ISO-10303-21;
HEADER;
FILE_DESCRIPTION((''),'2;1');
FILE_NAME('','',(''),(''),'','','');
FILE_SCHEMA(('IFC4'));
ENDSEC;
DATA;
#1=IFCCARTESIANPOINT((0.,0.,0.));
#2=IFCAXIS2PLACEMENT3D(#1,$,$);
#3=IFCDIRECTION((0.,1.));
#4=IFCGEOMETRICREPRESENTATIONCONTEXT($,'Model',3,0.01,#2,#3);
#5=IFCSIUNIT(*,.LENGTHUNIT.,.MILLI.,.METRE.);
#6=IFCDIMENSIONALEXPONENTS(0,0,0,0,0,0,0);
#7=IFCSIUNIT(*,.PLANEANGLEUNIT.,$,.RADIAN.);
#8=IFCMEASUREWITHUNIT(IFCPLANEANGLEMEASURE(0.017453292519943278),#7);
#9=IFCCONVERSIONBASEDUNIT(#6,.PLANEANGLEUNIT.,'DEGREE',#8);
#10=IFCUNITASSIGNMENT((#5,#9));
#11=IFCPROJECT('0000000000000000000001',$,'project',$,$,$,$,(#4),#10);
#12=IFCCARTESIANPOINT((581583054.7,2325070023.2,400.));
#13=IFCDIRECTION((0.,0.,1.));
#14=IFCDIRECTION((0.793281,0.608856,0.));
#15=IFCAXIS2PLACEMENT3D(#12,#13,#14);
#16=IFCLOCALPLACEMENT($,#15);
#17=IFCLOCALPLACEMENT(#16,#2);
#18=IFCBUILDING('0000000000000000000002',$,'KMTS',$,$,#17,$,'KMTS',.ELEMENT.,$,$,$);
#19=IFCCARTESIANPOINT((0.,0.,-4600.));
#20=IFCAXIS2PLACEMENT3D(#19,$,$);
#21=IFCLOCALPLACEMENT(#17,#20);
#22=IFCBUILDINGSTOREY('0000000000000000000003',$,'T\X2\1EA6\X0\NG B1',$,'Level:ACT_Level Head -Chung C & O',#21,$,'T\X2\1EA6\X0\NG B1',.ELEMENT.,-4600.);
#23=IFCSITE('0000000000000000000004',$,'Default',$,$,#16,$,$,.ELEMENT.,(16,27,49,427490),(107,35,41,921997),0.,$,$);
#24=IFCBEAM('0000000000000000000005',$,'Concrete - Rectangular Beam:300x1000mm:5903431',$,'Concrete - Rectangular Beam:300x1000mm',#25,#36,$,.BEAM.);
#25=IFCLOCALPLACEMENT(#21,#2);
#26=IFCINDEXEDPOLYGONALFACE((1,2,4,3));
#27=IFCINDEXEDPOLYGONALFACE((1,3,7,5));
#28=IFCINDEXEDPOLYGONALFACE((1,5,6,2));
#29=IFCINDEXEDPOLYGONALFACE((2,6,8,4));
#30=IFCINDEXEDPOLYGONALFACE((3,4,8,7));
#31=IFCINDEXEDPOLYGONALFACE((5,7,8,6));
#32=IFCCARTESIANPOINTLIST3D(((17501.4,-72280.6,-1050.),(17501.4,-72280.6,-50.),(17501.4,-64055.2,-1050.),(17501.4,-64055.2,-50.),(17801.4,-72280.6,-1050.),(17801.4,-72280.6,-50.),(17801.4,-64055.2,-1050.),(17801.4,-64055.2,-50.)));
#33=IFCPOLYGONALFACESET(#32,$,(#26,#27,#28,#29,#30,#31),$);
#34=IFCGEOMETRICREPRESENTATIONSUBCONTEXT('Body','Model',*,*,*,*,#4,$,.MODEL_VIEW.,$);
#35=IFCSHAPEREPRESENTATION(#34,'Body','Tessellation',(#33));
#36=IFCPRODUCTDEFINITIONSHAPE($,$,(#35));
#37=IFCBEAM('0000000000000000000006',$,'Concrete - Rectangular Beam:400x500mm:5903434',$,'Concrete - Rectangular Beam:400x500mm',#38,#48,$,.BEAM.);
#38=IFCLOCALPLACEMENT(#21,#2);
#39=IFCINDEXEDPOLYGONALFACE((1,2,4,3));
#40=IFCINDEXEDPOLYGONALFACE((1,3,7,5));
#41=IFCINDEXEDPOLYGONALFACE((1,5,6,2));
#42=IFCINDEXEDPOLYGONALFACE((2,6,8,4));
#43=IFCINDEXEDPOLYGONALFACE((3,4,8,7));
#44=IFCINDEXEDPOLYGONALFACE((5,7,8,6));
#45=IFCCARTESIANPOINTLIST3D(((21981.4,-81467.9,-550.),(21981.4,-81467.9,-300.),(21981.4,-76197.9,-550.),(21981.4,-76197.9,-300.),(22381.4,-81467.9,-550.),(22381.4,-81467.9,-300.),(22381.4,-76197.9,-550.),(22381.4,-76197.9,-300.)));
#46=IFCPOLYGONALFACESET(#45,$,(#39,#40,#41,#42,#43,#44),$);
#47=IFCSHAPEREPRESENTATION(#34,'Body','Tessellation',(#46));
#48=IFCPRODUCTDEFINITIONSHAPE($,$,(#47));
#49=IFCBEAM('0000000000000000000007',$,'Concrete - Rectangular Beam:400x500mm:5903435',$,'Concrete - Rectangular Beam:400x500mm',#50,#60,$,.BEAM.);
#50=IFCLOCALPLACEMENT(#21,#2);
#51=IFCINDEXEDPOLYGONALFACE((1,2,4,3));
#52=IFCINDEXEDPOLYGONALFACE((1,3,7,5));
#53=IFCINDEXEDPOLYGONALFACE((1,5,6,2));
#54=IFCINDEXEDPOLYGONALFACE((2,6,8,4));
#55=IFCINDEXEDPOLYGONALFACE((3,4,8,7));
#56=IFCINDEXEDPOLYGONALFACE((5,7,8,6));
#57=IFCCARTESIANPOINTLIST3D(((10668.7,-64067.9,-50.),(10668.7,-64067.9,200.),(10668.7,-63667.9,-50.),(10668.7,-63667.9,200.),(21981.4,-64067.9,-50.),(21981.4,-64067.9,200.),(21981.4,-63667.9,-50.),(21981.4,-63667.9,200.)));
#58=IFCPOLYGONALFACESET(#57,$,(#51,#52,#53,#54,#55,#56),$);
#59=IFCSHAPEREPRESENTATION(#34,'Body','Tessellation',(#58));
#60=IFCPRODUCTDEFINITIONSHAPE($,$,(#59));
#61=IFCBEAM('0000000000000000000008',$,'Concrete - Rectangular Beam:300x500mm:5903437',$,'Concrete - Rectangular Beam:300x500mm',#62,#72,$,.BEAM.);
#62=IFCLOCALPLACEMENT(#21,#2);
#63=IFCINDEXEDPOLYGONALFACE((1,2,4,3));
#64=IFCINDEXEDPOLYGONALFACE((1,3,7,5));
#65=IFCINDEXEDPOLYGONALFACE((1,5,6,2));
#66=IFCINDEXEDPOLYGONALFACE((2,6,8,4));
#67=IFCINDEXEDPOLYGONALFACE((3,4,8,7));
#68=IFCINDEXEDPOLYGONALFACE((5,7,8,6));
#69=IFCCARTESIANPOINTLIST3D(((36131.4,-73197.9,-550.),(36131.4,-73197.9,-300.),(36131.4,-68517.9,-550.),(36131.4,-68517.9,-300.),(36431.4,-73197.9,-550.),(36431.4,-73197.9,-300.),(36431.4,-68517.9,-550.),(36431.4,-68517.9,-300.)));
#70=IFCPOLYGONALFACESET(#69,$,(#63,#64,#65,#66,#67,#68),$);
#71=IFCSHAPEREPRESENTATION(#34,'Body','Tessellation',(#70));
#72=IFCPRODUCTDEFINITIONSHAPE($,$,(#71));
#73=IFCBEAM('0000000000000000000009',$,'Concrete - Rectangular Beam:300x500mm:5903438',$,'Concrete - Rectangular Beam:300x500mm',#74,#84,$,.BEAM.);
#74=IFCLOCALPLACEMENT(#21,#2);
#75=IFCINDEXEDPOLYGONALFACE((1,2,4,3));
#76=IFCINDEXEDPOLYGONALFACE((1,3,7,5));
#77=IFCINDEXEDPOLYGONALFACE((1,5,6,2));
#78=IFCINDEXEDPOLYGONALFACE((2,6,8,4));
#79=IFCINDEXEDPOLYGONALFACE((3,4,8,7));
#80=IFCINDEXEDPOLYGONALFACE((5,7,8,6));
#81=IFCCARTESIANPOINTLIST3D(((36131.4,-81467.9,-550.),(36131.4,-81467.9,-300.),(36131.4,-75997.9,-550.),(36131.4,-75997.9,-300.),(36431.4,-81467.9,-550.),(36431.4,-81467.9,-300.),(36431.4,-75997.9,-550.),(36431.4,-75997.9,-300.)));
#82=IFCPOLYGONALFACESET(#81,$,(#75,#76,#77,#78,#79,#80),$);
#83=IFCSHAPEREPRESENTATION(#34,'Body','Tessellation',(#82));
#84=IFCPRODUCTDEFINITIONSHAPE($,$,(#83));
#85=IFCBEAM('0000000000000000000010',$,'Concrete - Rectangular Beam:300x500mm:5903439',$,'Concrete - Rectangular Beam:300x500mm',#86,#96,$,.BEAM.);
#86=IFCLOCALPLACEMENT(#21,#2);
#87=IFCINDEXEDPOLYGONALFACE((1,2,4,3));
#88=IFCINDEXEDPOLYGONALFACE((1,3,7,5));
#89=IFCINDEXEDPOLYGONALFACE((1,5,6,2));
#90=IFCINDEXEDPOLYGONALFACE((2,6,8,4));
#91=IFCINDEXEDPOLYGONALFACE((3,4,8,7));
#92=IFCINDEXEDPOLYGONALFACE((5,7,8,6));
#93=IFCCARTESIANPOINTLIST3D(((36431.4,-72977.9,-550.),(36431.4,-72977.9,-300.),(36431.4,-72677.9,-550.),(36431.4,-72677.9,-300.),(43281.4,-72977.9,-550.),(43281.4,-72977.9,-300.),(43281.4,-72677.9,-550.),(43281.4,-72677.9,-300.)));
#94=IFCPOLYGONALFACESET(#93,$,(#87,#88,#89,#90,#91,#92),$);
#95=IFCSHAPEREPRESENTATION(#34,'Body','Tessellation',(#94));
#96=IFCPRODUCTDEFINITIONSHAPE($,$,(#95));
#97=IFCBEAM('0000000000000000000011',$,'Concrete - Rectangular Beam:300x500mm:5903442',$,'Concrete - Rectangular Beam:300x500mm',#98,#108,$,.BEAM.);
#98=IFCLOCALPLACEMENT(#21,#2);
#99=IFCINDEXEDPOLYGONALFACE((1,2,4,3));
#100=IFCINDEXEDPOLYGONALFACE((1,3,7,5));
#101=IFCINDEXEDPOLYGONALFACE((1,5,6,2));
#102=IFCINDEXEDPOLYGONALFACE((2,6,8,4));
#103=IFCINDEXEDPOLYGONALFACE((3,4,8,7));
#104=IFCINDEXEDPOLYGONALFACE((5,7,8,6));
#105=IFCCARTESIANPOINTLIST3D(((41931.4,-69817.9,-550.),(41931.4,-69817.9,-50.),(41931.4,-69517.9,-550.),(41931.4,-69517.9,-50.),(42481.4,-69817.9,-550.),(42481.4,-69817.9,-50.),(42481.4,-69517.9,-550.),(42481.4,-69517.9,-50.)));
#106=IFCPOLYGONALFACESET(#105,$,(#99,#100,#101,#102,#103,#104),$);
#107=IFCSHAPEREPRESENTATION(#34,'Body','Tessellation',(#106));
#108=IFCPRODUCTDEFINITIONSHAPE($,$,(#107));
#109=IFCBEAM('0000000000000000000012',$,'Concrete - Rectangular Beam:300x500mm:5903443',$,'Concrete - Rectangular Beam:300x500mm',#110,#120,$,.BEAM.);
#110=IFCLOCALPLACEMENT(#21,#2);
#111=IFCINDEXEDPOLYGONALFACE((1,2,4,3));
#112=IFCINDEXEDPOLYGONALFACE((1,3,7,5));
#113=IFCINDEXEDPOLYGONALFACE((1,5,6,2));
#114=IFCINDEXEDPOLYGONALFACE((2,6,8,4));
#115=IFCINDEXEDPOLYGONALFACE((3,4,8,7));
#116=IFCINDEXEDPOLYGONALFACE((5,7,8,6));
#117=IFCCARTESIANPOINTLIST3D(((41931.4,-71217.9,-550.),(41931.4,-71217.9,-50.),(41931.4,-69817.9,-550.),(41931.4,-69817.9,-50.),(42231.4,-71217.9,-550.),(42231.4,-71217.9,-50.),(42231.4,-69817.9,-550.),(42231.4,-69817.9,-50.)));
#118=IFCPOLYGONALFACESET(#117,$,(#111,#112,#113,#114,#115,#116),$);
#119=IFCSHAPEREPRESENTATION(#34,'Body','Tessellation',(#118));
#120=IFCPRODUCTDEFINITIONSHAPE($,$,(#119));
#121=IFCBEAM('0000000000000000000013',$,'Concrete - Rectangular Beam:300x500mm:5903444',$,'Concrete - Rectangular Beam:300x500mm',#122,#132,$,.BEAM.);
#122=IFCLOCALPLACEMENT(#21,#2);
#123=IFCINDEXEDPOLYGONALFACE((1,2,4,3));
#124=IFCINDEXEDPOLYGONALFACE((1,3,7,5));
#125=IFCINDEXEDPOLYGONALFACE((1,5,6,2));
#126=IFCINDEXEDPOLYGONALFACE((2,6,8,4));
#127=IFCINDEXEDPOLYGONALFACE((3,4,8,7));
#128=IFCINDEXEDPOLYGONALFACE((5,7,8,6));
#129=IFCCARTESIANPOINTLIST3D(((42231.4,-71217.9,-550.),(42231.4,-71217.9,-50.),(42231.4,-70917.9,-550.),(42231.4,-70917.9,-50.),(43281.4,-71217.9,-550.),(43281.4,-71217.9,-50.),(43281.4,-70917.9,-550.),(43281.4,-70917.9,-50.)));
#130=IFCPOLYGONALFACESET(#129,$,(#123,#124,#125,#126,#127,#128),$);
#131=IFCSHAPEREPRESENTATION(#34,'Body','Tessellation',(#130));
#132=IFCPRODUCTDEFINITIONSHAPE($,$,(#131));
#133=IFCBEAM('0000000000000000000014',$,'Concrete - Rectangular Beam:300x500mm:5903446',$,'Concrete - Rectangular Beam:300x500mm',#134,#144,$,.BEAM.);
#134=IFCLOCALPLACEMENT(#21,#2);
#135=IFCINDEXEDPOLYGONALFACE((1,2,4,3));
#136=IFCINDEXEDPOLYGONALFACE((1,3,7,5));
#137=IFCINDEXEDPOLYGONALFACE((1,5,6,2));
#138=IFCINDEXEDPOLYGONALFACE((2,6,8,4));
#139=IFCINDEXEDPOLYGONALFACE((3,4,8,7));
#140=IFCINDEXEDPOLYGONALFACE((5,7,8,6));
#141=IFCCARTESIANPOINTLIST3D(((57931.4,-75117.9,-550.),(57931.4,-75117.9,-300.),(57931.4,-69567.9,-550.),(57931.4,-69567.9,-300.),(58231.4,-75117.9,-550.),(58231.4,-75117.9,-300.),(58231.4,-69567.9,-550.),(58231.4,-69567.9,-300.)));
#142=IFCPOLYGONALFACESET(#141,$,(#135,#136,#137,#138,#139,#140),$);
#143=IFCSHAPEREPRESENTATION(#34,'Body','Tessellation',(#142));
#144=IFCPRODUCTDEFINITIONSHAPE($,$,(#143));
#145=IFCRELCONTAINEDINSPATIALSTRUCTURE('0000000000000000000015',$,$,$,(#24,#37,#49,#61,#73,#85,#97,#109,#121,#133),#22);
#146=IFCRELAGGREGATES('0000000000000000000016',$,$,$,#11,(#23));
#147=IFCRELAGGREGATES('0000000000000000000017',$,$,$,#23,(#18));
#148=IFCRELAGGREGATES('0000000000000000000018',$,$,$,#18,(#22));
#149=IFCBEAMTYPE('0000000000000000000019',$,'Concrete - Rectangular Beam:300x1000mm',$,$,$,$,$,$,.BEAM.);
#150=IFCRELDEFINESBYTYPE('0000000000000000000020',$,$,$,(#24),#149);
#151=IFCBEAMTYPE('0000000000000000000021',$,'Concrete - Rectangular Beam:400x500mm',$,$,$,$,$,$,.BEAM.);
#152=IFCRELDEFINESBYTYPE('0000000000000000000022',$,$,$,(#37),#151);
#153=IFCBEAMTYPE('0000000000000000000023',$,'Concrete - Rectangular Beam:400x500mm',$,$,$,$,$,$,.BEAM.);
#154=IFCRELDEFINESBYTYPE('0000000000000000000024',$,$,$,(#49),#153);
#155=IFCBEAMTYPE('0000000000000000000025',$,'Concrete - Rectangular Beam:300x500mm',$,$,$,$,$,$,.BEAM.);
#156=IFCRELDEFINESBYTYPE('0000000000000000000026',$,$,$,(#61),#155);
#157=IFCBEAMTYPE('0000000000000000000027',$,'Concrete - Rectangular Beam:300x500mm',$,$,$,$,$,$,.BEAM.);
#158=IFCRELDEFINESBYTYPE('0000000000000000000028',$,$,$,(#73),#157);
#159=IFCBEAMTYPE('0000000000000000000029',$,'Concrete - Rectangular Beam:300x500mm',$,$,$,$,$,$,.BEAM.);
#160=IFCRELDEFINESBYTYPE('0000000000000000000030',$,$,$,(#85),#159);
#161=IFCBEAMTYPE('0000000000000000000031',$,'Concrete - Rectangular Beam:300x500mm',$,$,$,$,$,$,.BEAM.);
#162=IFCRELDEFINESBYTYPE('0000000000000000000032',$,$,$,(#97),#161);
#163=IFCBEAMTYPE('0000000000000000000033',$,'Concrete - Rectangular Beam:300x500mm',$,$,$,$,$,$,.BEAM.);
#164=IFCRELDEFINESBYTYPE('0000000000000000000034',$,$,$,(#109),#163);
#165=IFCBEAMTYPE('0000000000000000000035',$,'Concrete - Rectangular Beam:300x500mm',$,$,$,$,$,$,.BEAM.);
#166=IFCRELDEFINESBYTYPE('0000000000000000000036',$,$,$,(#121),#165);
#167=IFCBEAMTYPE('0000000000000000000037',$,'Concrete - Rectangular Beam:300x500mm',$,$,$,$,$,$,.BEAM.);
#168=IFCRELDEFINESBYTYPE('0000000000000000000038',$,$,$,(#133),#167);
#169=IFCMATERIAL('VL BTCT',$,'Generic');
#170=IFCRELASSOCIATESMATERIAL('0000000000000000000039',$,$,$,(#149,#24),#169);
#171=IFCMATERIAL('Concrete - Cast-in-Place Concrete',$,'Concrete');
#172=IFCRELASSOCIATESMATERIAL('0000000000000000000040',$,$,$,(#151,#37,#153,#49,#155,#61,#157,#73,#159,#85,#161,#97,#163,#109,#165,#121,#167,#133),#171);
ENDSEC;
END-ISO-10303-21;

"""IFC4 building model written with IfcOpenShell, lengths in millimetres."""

from ifc_helpers import new_model, entity, si_unit, converted_unit, direction, frame, origin, place, context, subcontext, project, spatial, indexed_curve, outline, extrude, source, transform, mapped, material, type_object, type_shapes, element, save


model = new_model("IFC4")

# Units and contexts
model_context = context("Model", 3, precision=0.01, world=origin(), true_north=direction((0.0, 1.0)))
body_context = subcontext(model_context, "Body", "Model", "MODEL_VIEW")
ifc_project = project(units=[si_unit("LENGTHUNIT", "METRE", prefix="MILLI"), converted_unit("PLANEANGLEUNIT", "DEGREE", entity("IfcPlaneAngleMeasure", 0.017453292519943278), si_unit("PLANEANGLEUNIT", "RADIAN"), dimensions=[0, 0, 0, 0, 0, 0, 0])], contexts=[model_context])

# Site, building, storey
site_placement = place(None, frame((581583054.7, 2325070023.2, 400.0), z_axis=(0.0, 0.0, 1.0), x_axis=(0.793281, 0.608856, 0.0)))
site = spatial("IfcSite", under=ifc_project, at=site_placement, Name="Default", CompositionType="ELEMENT", RefLatitude=(16, 27, 49, 427490), RefLongitude=(107, 35, 41, 921997), RefElevation=0.0)
building_placement = place(site_placement, origin())
building = spatial("IfcBuilding", under=site, at=building_placement, Name="KMTS", LongName="KMTS", CompositionType="ELEMENT")
storey_placement = place(building_placement, frame((0.0, 0.0, -4600.0)))
storey = spatial("IfcBuildingStorey", under=building, at=storey_placement, Name="TẦNG B1", ObjectType="Level:ACT_Level Head -Chung C & O", LongName="TẦNG B1", CompositionType="ELEMENT", Elevation=-4600.0)

# Shared definitions
ifc_material_1 = material(Name="VL BTCT", Category="Generic")

# Beams
beam_type_1 = type_object("IfcBeamType", Name="Concrete - Rectangular Beam:300x1000mm", PredefinedType="BEAM", material=ifc_material_1)
shared_shape_1 = source(origin(), body_context, "Body", "SweptSolid", [
    extrude(outline(indexed_curve([(-150.0, -500.0), (150.0, -500.0), (150.0, 500.0), (-150.0, 500.0), (-150.0, -500.0)], self_intersect=False)), frame((17651.4, -72280.6, -5150.0), z_axis=(0.0, 1.0, 0.0), x_axis=(-1.0, 0.0, 0.0)), (0.0, 0.0, 1.0), 8225.4),
])
type_shapes(beam_type_1, [shared_shape_1])
beam_1_placement = place(storey_placement, frame((0.0, 0.0, 4600.0)))
element("IfcBeam", 1, at=beam_1_placement, inside=storey, type_object=beam_type_1, material=ifc_material_1, Name="Concrete - Rectangular Beam:300x1000mm:5903431", ObjectType="Concrete - Rectangular Beam:300x1000mm", PredefinedType="BEAM", context=body_context, shape_type="MappedRepresentation", body=[
    mapped(shared_shape_1, transform((0.0, 0.0, 0.0), scale=1.0)),
])
ifc_material_2 = material(Name="Concrete - Cast-in-Place Concrete", Category="Concrete")
beam_type_2 = type_object("IfcBeamType", Name="Concrete - Rectangular Beam:400x500mm", PredefinedType="BEAM", material=ifc_material_2)
shared_shape_2 = source(origin(), body_context, "Body", "SweptSolid", [
    extrude(outline(indexed_curve([(-200.0, -125.0), (200.0, -125.0), (200.0, 125.0), (-200.0, 125.0), (-200.0, -125.0)], self_intersect=False)), frame((22181.4, -81467.9, -5025.0), z_axis=(0.0, 1.0, 0.0), x_axis=(-1.0, 0.0, 0.0)), (0.0, 0.0, 1.0), 5270.0),
])
type_shapes(beam_type_2, [shared_shape_2])
beam_2_placement = place(storey_placement, frame((0.0, 0.0, 4600.0)))
element("IfcBeam", 2, at=beam_2_placement, inside=storey, type_object=beam_type_2, material=ifc_material_2, Name="Concrete - Rectangular Beam:400x500mm:5903434", ObjectType="Concrete - Rectangular Beam:400x500mm", PredefinedType="BEAM", context=body_context, shape_type="MappedRepresentation", body=[
    mapped(shared_shape_2, transform((0.0, 0.0, 0.0), scale=1.0)),
])
beam_type_3 = type_object("IfcBeamType", Name="Concrete - Rectangular Beam:400x500mm", PredefinedType="BEAM", material=ifc_material_2)
shared_shape_3 = source(origin(), body_context, "Body", "SweptSolid", [
    extrude(outline(indexed_curve([(-125.0, -200.0), (125.0, -200.0), (125.0, 200.0), (-125.0, 200.0), (-125.0, -200.0)], self_intersect=False)), frame((21981.4, -63867.9, -4525.0), z_axis=(-1.0, 0.0, 0.0), x_axis=(0.0, 0.0, -1.0)), (0.0, 0.0, 1.0), 11312.7),
])
type_shapes(beam_type_3, [shared_shape_3])
beam_3_placement = place(storey_placement, frame((0.0, 0.0, 4600.0)))
element("IfcBeam", 3, at=beam_3_placement, inside=storey, type_object=beam_type_3, material=ifc_material_2, Name="Concrete - Rectangular Beam:400x500mm:5903435", ObjectType="Concrete - Rectangular Beam:400x500mm", PredefinedType="BEAM", context=body_context, shape_type="MappedRepresentation", body=[
    mapped(shared_shape_3, transform((0.0, 0.0, 0.0), scale=1.0)),
])
beam_type_4 = type_object("IfcBeamType", Name="Concrete - Rectangular Beam:300x500mm", PredefinedType="BEAM", material=ifc_material_2)
shared_shape_4 = source(origin(), body_context, "Body", "SweptSolid", [
    extrude(outline(indexed_curve([(-150.0, -125.0), (150.0, -125.0), (150.0, 125.0), (-150.0, 125.0), (-150.0, -125.0)], self_intersect=False)), frame((36281.4, -73197.9, -5025.0), z_axis=(0.0, 1.0, 0.0), x_axis=(-1.0, 0.0, 0.0)), (0.0, 0.0, 1.0), 4680.0),
])
type_shapes(beam_type_4, [shared_shape_4])
beam_4_placement = place(storey_placement, frame((0.0, 0.0, 4600.0)))
element("IfcBeam", 4, at=beam_4_placement, inside=storey, type_object=beam_type_4, material=ifc_material_2, Name="Concrete - Rectangular Beam:300x500mm:5903437", ObjectType="Concrete - Rectangular Beam:300x500mm", PredefinedType="BEAM", context=body_context, shape_type="MappedRepresentation", body=[
    mapped(shared_shape_4, transform((0.0, 0.0, 0.0), scale=1.0)),
])
beam_type_5 = type_object("IfcBeamType", Name="Concrete - Rectangular Beam:300x500mm", PredefinedType="BEAM", material=ifc_material_2)
shared_shape_5 = source(origin(), body_context, "Body", "SweptSolid", [
    extrude(outline(indexed_curve([(-150.0, -125.0), (150.0, -125.0), (150.0, 125.0), (-150.0, 125.0), (-150.0, -125.0)], self_intersect=False)), frame((36281.4, -81467.9, -5025.0), z_axis=(0.0, 1.0, 0.0), x_axis=(-1.0, 0.0, 0.0)), (0.0, 0.0, 1.0), 5470.0),
])
type_shapes(beam_type_5, [shared_shape_5])
beam_5_placement = place(storey_placement, frame((0.0, 0.0, 4600.0)))
element("IfcBeam", 5, at=beam_5_placement, inside=storey, type_object=beam_type_5, material=ifc_material_2, Name="Concrete - Rectangular Beam:300x500mm:5903438", ObjectType="Concrete - Rectangular Beam:300x500mm", PredefinedType="BEAM", context=body_context, shape_type="MappedRepresentation", body=[
    mapped(shared_shape_5, transform((0.0, 0.0, 0.0), scale=1.0)),
])
beam_type_6 = type_object("IfcBeamType", Name="Concrete - Rectangular Beam:300x500mm", PredefinedType="BEAM", material=ifc_material_2)
shared_shape_6 = source(origin(), body_context, "Body", "SweptSolid", [
    extrude(outline(indexed_curve([(-125.0, -150.0), (125.0, -150.0), (125.0, 150.0), (-125.0, 150.0), (-125.0, -150.0)], self_intersect=False)), frame((43281.4, -72827.9, -5025.0), z_axis=(-1.0, 0.0, 0.0), x_axis=(0.0, 0.0, -1.0)), (0.0, 0.0, 1.0), 6850.0),
])
type_shapes(beam_type_6, [shared_shape_6])
beam_6_placement = place(storey_placement, frame((0.0, 0.0, 4600.0)))
element("IfcBeam", 6, at=beam_6_placement, inside=storey, type_object=beam_type_6, material=ifc_material_2, Name="Concrete - Rectangular Beam:300x500mm:5903439", ObjectType="Concrete - Rectangular Beam:300x500mm", PredefinedType="BEAM", context=body_context, shape_type="MappedRepresentation", body=[
    mapped(shared_shape_6, transform((0.0, 0.0, 0.0), scale=1.0)),
])
beam_type_7 = type_object("IfcBeamType", Name="Concrete - Rectangular Beam:300x500mm", PredefinedType="BEAM", material=ifc_material_2)
shared_shape_7 = source(origin(), body_context, "Body", "SweptSolid", [
    extrude(outline(indexed_curve([(-250.0, -150.0), (250.0, -150.0), (250.0, 150.0), (-250.0, 150.0), (-250.0, -150.0)], self_intersect=False)), frame((42481.4, -69667.9, -4900.0), z_axis=(-1.0, 0.0, 0.0), x_axis=(0.0, 0.0, -1.0)), (0.0, 0.0, 1.0), 550.0),
])
type_shapes(beam_type_7, [shared_shape_7])
beam_7_placement = place(storey_placement, frame((0.0, 0.0, 4600.0)))
element("IfcBeam", 7, at=beam_7_placement, inside=storey, type_object=beam_type_7, material=ifc_material_2, Name="Concrete - Rectangular Beam:300x500mm:5903442", ObjectType="Concrete - Rectangular Beam:300x500mm", PredefinedType="BEAM", context=body_context, shape_type="MappedRepresentation", body=[
    mapped(shared_shape_7, transform((0.0, 0.0, 0.0), scale=1.0)),
])
beam_type_8 = type_object("IfcBeamType", Name="Concrete - Rectangular Beam:300x500mm", PredefinedType="BEAM", material=ifc_material_2)
shared_shape_8 = source(origin(), body_context, "Body", "SweptSolid", [
    extrude(outline(indexed_curve([(-150.0, -250.0), (150.0, -250.0), (150.0, 250.0), (-150.0, 250.0), (-150.0, -250.0)], self_intersect=False)), frame((42081.4, -69817.9, -4900.0), z_axis=(0.0, -1.0, 0.0), x_axis=(-1.0, 0.0, 0.0)), (0.0, 0.0, 1.0), 1400.0),
])
type_shapes(beam_type_8, [shared_shape_8])
beam_8_placement = place(storey_placement, frame((0.0, 0.0, 4600.0)))
element("IfcBeam", 8, at=beam_8_placement, inside=storey, type_object=beam_type_8, material=ifc_material_2, Name="Concrete - Rectangular Beam:300x500mm:5903443", ObjectType="Concrete - Rectangular Beam:300x500mm", PredefinedType="BEAM", context=body_context, shape_type="MappedRepresentation", body=[
    mapped(shared_shape_8, transform((0.0, 0.0, 0.0), scale=1.0)),
])
beam_type_9 = type_object("IfcBeamType", Name="Concrete - Rectangular Beam:300x500mm", PredefinedType="BEAM", material=ifc_material_2)
shared_shape_9 = source(origin(), body_context, "Body", "SweptSolid", [
    extrude(outline(indexed_curve([(-250.0, -150.0), (250.0, -150.0), (250.0, 150.0), (-250.0, 150.0), (-250.0, -150.0)], self_intersect=False)), frame((42231.4, -71067.9, -4900.0), z_axis=(1.0, 0.0, 0.0), x_axis=(0.0, 0.0, -1.0)), (0.0, 0.0, 1.0), 1050.0),
])
type_shapes(beam_type_9, [shared_shape_9])
beam_9_placement = place(storey_placement, frame((0.0, 0.0, 4600.0)))
element("IfcBeam", 9, at=beam_9_placement, inside=storey, type_object=beam_type_9, material=ifc_material_2, Name="Concrete - Rectangular Beam:300x500mm:5903444", ObjectType="Concrete - Rectangular Beam:300x500mm", PredefinedType="BEAM", context=body_context, shape_type="MappedRepresentation", body=[
    mapped(shared_shape_9, transform((0.0, 0.0, 0.0), scale=1.0)),
])
beam_type_10 = type_object("IfcBeamType", Name="Concrete - Rectangular Beam:300x500mm", PredefinedType="BEAM", material=ifc_material_2)
shared_shape_10 = source(origin(), body_context, "Body", "SweptSolid", [
    extrude(outline(indexed_curve([(-150.0, -125.0), (150.0, -125.0), (150.0, 125.0), (-150.0, 125.0), (-150.0, -125.0)], self_intersect=False)), frame((58081.4, -75117.9, -5025.0), z_axis=(0.0, 1.0, 0.0), x_axis=(-1.0, 0.0, 0.0)), (0.0, 0.0, 1.0), 5550.0),
])
type_shapes(beam_type_10, [shared_shape_10])
beam_10_placement = place(storey_placement, frame((0.0, 0.0, 4600.0)))
element("IfcBeam", 10, at=beam_10_placement, inside=storey, type_object=beam_type_10, material=ifc_material_2, Name="Concrete - Rectangular Beam:300x500mm:5903446", ObjectType="Concrete - Rectangular Beam:300x500mm", PredefinedType="BEAM", context=body_context, shape_type="MappedRepresentation", body=[
    mapped(shared_shape_10, transform((0.0, 0.0, 0.0), scale=1.0)),
])

save(model, "model.ifc")
